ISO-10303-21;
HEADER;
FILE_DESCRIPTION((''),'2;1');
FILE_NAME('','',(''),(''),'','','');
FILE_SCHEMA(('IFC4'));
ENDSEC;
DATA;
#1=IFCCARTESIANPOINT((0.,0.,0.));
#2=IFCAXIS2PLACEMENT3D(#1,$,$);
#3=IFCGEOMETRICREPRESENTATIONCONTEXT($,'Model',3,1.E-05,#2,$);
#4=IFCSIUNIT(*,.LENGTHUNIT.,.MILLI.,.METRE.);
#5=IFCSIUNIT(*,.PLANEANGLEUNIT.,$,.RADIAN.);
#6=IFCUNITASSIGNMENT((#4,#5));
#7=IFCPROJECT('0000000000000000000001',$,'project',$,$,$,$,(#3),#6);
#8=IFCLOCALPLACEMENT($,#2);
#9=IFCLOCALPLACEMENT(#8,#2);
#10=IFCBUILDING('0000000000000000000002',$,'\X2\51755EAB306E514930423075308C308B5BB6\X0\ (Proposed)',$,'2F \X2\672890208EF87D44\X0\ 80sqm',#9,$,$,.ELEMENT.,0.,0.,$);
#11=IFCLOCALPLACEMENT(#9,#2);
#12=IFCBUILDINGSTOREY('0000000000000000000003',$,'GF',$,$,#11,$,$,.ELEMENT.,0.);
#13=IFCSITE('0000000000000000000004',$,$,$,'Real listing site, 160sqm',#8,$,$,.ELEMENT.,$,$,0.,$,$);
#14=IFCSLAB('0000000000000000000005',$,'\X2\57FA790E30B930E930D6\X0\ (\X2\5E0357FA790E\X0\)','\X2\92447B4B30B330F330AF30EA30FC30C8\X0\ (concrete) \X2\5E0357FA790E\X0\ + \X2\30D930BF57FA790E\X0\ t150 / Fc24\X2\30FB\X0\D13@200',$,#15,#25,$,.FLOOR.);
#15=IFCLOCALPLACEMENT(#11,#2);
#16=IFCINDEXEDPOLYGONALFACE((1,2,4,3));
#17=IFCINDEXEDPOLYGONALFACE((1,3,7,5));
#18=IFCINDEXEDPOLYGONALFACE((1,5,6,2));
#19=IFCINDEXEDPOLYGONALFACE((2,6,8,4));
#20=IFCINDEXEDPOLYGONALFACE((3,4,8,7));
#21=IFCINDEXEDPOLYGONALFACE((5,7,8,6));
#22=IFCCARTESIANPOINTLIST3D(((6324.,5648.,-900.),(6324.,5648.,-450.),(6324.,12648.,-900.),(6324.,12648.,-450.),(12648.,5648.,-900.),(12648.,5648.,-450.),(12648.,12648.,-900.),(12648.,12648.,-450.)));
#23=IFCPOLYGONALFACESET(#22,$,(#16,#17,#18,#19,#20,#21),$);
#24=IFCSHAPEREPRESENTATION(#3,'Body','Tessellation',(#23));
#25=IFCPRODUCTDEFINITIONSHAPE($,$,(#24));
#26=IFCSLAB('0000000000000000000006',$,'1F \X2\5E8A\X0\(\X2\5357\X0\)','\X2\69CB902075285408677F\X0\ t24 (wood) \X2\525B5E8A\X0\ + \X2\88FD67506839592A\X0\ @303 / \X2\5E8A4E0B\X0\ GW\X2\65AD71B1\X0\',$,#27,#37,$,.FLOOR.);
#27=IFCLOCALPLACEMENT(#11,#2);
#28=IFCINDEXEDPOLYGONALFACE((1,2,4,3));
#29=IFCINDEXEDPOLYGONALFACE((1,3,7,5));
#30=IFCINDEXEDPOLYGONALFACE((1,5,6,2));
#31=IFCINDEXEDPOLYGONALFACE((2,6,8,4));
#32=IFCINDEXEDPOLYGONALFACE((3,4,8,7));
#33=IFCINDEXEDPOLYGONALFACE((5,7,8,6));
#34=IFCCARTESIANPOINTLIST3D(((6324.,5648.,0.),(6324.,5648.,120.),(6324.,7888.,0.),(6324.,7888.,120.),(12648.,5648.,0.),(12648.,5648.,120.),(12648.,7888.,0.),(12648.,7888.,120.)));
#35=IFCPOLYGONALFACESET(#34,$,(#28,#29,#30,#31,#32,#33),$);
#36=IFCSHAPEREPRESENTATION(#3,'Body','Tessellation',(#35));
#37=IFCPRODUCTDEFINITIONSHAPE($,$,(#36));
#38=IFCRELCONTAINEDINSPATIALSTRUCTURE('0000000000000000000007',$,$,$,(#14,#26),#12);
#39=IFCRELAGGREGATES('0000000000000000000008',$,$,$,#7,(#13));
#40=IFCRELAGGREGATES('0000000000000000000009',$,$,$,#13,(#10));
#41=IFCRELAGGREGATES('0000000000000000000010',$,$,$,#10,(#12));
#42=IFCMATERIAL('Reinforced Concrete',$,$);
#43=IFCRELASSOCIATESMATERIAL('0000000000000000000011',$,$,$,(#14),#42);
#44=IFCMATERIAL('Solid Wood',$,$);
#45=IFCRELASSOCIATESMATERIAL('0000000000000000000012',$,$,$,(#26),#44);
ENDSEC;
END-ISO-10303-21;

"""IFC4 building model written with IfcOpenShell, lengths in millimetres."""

from ifc_helpers import new_model, si_unit, frame, frame_2d, origin, place, context, project, spatial, rectangle, extrude, material, element, save


model = new_model("IFC4")

# Units and contexts
model_context = context("Model", 3, precision=1e-05, world=origin())
ifc_project = project(units=[si_unit("LENGTHUNIT", "METRE", prefix="MILLI"), si_unit("PLANEANGLEUNIT", "RADIAN")], contexts=[model_context])

# Site, building, storey
site_placement = place(None, origin())
site = spatial("IfcSite", under=ifc_project, at=site_placement, ObjectType="Real listing site, 160sqm", CompositionType="ELEMENT", RefElevation=0.0)
building_placement = place(site_placement, origin())
building = spatial("IfcBuilding", under=site, at=building_placement, Name="兵庫の光あふれる家 (Proposed)", ObjectType="2F 木造軸組 80sqm", CompositionType="ELEMENT", ElevationOfRefHeight=0.0, ElevationOfTerrain=0.0)
storey_placement = place(building_placement, origin())
storey = spatial("IfcBuildingStorey", under=building, at=storey_placement, Name="GF", CompositionType="ELEMENT", Elevation=0.0)

# Slabs
ifc_material_1 = material(Name="Reinforced Concrete")
slab_1_placement = place(storey_placement, frame((3162.0, 2824.0, -450.0)))
element("IfcSlab", 1, at=slab_1_placement, inside=storey, material=ifc_material_1, Name="基礎スラブ (布基礎)", Description="鉄筋コンクリート (concrete) 布基礎 + ベタ基礎 t150 / Fc24・D13@200", PredefinedType="FLOOR", context=model_context, shape_type="SweptSolid", body=[
    extrude(rectangle(XDim=6324.0, YDim=7000.0, at=frame_2d((3162.0, 3500.0))), frame((3162.0, 2824.0, -450.0)), (0.0, 0.0, 1.0), 450.0),
])
ifc_material_2 = material(Name="Solid Wood")
slab_2_placement = place(storey_placement, frame((3162.0, 2824.0, 0.0)))
element("IfcSlab", 2, at=slab_2_placement, inside=storey, material=ifc_material_2, Name="1F 床(南)", Description="構造用合板 t24 (wood) 剛床 + 製材根太 @303 / 床下 GW断熱", PredefinedType="FLOOR", context=model_context, shape_type="SweptSolid", body=[
    extrude(rectangle(XDim=6324.0, YDim=2240.0, at=frame_2d((3162.0, 1120.0))), frame((3162.0, 2824.0, 0.0)), (0.0, 0.0, 1.0), 120.0),
])

save(model, "model.ifc")
